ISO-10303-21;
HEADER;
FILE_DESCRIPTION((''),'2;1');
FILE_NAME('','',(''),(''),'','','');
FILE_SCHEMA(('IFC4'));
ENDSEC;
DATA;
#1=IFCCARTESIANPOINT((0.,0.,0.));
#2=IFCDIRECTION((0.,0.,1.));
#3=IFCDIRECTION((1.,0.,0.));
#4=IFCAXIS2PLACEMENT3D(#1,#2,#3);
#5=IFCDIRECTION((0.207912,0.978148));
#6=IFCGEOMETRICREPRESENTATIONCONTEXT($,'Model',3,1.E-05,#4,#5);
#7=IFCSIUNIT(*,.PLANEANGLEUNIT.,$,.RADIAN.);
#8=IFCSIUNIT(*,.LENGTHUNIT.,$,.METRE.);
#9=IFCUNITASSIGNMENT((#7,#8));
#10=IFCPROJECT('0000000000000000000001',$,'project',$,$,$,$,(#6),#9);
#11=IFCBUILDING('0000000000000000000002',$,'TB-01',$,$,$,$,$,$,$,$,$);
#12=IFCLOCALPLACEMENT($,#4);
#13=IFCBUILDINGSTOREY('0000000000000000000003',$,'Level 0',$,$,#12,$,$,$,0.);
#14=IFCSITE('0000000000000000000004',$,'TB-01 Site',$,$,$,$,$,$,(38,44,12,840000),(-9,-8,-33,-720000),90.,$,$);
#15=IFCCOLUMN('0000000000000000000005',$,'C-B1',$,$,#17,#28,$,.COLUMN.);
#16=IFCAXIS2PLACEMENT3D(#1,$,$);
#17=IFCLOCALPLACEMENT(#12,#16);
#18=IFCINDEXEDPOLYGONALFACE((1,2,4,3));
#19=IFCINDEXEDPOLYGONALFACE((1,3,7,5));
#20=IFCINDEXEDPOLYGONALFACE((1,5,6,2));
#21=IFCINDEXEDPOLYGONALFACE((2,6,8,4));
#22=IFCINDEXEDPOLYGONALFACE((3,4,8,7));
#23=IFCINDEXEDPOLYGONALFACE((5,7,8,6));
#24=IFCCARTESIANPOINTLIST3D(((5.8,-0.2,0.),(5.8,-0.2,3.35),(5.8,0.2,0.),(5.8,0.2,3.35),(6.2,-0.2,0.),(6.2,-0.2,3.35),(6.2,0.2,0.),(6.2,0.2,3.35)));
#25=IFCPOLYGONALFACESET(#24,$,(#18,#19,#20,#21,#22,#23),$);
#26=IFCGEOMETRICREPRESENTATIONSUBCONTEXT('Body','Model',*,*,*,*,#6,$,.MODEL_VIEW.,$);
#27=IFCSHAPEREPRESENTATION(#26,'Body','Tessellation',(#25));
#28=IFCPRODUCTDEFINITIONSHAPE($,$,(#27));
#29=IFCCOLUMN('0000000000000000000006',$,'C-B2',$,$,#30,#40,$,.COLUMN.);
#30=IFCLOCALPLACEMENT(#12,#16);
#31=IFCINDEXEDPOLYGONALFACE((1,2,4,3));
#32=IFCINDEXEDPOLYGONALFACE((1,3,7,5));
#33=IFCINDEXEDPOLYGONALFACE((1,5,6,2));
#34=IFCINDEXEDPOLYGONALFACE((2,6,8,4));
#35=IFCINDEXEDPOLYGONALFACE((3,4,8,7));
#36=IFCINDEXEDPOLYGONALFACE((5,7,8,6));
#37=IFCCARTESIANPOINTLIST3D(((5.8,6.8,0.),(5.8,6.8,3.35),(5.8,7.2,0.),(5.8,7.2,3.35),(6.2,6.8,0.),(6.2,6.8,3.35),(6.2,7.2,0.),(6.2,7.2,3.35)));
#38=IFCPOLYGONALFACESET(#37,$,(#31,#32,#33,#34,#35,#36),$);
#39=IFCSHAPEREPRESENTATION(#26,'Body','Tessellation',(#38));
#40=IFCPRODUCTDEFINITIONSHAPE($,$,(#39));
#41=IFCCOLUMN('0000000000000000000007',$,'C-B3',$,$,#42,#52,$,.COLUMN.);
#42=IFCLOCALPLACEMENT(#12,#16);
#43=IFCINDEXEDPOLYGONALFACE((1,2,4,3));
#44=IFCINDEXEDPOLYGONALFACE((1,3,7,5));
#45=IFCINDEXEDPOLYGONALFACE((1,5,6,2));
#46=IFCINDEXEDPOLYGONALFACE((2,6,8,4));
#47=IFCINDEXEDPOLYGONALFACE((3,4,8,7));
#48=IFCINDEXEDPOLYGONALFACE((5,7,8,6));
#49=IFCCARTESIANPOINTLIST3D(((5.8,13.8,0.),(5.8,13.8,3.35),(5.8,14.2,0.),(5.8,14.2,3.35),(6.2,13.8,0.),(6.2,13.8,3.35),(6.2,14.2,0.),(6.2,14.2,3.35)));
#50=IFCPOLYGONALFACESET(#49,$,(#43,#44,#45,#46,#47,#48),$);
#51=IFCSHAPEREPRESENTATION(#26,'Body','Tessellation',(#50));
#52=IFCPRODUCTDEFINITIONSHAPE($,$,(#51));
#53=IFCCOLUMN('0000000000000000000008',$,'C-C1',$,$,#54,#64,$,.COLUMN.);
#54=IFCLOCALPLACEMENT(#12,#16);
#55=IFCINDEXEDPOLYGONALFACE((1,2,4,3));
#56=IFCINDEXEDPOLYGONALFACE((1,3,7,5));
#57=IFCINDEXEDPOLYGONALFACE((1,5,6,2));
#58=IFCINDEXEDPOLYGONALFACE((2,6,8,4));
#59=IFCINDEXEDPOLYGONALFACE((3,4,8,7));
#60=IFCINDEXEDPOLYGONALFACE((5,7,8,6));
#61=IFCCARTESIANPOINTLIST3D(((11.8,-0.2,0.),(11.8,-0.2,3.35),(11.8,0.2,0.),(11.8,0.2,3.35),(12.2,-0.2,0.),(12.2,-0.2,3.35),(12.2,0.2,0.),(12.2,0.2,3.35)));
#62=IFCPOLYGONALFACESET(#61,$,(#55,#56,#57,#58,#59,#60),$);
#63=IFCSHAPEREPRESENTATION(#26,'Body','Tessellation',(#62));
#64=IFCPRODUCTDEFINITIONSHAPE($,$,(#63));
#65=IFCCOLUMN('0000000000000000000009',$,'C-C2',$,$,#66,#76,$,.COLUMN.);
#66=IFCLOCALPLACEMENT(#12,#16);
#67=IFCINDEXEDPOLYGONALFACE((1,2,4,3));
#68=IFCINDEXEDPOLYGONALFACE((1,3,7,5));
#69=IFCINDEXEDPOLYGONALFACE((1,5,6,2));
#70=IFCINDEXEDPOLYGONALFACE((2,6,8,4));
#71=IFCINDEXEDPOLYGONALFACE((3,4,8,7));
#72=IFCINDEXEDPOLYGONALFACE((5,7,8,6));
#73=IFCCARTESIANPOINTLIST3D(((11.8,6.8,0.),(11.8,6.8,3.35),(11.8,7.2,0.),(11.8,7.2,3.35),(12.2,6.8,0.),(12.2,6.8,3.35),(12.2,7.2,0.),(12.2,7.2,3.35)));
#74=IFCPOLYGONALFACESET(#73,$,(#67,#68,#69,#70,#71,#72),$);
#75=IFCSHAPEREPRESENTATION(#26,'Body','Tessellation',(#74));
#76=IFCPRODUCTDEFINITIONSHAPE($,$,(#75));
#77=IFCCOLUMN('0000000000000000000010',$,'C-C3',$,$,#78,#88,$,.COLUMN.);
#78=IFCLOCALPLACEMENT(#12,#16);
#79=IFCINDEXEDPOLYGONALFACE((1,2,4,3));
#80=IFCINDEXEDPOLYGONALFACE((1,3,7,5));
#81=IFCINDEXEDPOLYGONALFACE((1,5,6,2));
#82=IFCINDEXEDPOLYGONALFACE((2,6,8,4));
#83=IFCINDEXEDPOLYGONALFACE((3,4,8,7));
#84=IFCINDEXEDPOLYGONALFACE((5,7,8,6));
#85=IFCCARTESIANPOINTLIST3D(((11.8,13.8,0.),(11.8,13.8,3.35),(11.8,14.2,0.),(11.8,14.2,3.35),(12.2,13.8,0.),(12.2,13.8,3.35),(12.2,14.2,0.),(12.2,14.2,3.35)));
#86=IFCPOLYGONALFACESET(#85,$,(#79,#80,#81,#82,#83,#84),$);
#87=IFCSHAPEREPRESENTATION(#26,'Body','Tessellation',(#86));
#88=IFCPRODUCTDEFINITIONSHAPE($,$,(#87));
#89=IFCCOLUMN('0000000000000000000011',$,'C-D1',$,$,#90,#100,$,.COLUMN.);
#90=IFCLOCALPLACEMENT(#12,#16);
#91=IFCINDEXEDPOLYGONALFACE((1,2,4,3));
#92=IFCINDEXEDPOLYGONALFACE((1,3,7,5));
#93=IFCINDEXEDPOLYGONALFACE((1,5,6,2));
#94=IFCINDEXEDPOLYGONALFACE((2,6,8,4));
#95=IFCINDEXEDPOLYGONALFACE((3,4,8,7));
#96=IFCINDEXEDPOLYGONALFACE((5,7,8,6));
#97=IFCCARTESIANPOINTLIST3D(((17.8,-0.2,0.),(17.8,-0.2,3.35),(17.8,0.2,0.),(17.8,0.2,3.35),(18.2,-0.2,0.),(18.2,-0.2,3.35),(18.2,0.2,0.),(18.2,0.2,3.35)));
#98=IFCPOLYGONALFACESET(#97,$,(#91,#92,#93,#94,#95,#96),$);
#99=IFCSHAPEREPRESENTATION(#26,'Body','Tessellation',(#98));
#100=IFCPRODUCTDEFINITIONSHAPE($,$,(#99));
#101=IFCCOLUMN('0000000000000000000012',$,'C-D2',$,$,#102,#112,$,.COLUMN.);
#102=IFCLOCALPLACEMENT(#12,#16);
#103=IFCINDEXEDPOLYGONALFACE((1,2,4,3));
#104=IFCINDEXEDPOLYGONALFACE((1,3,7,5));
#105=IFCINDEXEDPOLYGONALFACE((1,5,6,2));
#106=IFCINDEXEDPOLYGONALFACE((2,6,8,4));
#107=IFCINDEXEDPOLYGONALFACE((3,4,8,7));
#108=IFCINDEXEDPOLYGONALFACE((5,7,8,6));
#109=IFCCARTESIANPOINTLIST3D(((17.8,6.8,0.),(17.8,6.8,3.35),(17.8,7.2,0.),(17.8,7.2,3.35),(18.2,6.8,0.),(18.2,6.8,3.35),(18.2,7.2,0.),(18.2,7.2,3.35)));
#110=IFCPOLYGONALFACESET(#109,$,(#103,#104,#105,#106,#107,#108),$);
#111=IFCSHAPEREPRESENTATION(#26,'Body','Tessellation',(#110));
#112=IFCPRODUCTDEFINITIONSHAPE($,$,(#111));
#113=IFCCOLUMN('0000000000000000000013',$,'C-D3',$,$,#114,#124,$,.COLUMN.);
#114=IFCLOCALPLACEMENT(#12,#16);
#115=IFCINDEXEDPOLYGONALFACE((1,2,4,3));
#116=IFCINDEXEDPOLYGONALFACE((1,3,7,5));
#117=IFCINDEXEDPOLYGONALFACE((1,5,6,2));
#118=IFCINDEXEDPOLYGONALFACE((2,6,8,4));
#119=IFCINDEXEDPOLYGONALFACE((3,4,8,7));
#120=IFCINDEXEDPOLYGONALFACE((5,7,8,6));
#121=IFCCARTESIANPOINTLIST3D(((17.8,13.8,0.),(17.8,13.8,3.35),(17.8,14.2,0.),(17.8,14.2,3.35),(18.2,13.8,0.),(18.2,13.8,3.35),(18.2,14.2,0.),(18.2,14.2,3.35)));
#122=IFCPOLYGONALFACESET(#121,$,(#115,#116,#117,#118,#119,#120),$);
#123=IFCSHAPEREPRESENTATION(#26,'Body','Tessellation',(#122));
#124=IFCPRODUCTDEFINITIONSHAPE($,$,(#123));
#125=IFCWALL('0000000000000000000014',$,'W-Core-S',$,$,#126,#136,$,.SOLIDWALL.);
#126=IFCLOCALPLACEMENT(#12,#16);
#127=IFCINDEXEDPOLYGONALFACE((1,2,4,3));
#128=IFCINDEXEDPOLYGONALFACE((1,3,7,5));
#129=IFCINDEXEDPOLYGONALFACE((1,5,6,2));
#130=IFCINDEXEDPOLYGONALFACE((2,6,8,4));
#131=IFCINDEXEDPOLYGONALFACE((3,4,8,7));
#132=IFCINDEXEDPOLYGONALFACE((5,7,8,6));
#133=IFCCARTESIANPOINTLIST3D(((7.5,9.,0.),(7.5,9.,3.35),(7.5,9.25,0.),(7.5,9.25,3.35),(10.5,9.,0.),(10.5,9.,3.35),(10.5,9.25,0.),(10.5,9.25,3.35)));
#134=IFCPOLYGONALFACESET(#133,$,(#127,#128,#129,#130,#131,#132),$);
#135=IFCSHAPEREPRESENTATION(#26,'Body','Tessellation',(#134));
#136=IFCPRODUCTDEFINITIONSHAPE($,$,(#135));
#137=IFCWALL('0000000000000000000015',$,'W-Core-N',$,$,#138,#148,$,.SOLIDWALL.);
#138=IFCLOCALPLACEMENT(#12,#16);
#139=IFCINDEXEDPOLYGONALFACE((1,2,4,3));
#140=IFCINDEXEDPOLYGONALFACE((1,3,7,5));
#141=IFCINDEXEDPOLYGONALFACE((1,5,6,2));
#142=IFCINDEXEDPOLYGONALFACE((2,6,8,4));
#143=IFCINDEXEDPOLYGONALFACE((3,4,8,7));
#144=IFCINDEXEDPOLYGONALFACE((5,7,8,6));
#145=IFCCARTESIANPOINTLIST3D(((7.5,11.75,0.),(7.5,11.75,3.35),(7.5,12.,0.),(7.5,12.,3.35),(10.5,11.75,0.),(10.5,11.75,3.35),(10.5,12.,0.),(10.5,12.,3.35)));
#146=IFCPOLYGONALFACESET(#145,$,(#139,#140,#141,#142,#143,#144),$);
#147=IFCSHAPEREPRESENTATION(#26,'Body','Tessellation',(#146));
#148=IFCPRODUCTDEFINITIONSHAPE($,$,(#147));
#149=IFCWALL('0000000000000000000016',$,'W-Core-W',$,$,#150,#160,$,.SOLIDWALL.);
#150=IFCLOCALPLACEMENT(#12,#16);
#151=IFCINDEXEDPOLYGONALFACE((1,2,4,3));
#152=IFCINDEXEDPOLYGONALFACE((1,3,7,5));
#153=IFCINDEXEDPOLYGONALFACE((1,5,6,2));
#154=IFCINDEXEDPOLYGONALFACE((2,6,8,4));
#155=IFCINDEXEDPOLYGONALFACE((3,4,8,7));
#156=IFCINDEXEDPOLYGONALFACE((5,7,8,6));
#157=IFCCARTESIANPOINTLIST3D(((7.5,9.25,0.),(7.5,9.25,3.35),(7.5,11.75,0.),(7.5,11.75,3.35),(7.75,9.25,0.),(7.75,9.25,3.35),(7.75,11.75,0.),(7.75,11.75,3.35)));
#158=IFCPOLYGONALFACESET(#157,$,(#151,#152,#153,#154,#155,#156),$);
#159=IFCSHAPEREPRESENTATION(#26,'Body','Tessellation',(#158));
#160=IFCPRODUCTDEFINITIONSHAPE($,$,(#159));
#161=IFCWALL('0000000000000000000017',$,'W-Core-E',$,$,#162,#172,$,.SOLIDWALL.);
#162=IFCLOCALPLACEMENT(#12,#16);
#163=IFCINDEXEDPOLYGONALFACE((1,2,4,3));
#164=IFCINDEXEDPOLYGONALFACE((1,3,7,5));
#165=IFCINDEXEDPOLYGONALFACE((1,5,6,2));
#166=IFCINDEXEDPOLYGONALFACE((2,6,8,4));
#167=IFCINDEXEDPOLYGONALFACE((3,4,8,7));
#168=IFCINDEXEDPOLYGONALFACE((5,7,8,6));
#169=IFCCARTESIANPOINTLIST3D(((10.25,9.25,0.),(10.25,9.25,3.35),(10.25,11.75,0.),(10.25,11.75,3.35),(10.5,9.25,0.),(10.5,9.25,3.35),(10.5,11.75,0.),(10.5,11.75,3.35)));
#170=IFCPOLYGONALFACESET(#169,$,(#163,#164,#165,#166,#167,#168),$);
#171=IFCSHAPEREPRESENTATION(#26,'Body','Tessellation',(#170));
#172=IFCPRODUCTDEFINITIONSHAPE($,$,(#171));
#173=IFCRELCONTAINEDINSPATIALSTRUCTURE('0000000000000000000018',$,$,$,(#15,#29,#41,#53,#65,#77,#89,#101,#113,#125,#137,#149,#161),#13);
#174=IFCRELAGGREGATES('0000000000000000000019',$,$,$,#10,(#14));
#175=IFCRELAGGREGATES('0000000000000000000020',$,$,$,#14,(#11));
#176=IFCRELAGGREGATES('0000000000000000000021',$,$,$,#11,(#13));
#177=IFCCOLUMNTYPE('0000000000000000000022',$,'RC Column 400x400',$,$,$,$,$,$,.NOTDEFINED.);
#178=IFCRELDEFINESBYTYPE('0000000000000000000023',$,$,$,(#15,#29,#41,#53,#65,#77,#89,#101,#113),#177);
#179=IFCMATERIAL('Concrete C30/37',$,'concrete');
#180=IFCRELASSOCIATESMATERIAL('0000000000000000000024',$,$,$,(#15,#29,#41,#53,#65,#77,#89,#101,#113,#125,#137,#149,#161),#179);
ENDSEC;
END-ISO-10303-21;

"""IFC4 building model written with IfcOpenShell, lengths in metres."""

from ifc_helpers import new_model, si_unit, direction, frame, origin_with_axes, place, context, subcontext, project, spatial, rectangle, extrude, material, type_object, element, save


model = new_model("IFC4")

# Units and contexts
model_context = context("Model", 3, precision=1e-05, world=origin_with_axes(), true_north=direction((0.207912, 0.978148)))
body_context = subcontext(model_context, "Body", "Model", "MODEL_VIEW")
ifc_project = project(units=[si_unit("PLANEANGLEUNIT", "RADIAN"), si_unit("LENGTHUNIT", "METRE")], contexts=[model_context])

# Site, building, storey
site = spatial("IfcSite", under=ifc_project, Name="TB-01 Site", RefLatitude=(38, 44, 12, 840000), RefLongitude=(-9, -8, -33, -720000), RefElevation=90.0)
building = spatial("IfcBuilding", under=site, Name="TB-01")
storey_placement = place(None, origin_with_axes())
storey = spatial("IfcBuildingStorey", under=building, at=storey_placement, Name="Level 0", Elevation=0.0)

# Columns
ifc_material_1 = material(Name="Concrete C30/37", Category="concrete")
column_type = type_object("IfcColumnType", Name="RC Column 400x400", PredefinedType="NOTDEFINED")
column_1_placement = place(storey_placement, frame((6.0, 0.0, 0.0), z_axis=(0.0, 0.0, 1.0), x_axis=(1.0, 0.0, 0.0)))
element("IfcColumn", 1, at=column_1_placement, inside=storey, type_object=column_type, material=ifc_material_1, Name="C-B1", PredefinedType="COLUMN", context=body_context, shape_type="SweptSolid", body=[
    extrude(rectangle(XDim=0.4, YDim=0.4), origin_with_axes(), (0.0, 0.0, 1.0), 3.35),
])
column_2_placement = place(storey_placement, frame((6.0, 7.0, 0.0), z_axis=(0.0, 0.0, 1.0), x_axis=(1.0, 0.0, 0.0)))
element("IfcColumn", 2, at=column_2_placement, inside=storey, type_object=column_type, material=ifc_material_1, Name="C-B2", PredefinedType="COLUMN", context=body_context, shape_type="SweptSolid", body=[
    extrude(rectangle(XDim=0.4, YDim=0.4), origin_with_axes(), (0.0, 0.0, 1.0), 3.35),
])
column_3_placement = place(storey_placement, frame((6.0, 14.0, 0.0), z_axis=(0.0, 0.0, 1.0), x_axis=(1.0, 0.0, 0.0)))
element("IfcColumn", 3, at=column_3_placement, inside=storey, type_object=column_type, material=ifc_material_1, Name="C-B3", PredefinedType="COLUMN", context=body_context, shape_type="SweptSolid", body=[
    extrude(rectangle(XDim=0.4, YDim=0.4), origin_with_axes(), (0.0, 0.0, 1.0), 3.35),
])
column_4_placement = place(storey_placement, frame((12.0, 0.0, 0.0), z_axis=(0.0, 0.0, 1.0), x_axis=(1.0, 0.0, 0.0)))
element("IfcColumn", 4, at=column_4_placement, inside=storey, type_object=column_type, material=ifc_material_1, Name="C-C1", PredefinedType="COLUMN", context=body_context, shape_type="SweptSolid", body=[
    extrude(rectangle(XDim=0.4, YDim=0.4), origin_with_axes(), (0.0, 0.0, 1.0), 3.35),
])
column_5_placement = place(storey_placement, frame((12.0, 7.0, 0.0), z_axis=(0.0, 0.0, 1.0), x_axis=(1.0, 0.0, 0.0)))
element("IfcColumn", 5, at=column_5_placement, inside=storey, type_object=column_type, material=ifc_material_1, Name="C-C2", PredefinedType="COLUMN", context=body_context, shape_type="SweptSolid", body=[
    extrude(rectangle(XDim=0.4, YDim=0.4), origin_with_axes(), (0.0, 0.0, 1.0), 3.35),
])
column_6_placement = place(storey_placement, frame((12.0, 14.0, 0.0), z_axis=(0.0, 0.0, 1.0), x_axis=(1.0, 0.0, 0.0)))
element("IfcColumn", 6, at=column_6_placement, inside=storey, type_object=column_type, material=ifc_material_1, Name="C-C3", PredefinedType="COLUMN", context=body_context, shape_type="SweptSolid", body=[
    extrude(rectangle(XDim=0.4, YDim=0.4), origin_with_axes(), (0.0, 0.0, 1.0), 3.35),
])
column_7_placement = place(storey_placement, frame((18.0, 0.0, 0.0), z_axis=(0.0, 0.0, 1.0), x_axis=(1.0, 0.0, 0.0)))
element("IfcColumn", 7, at=column_7_placement, inside=storey, type_object=column_type, material=ifc_material_1, Name="C-D1", PredefinedType="COLUMN", context=body_context, shape_type="SweptSolid", body=[
    extrude(rectangle(XDim=0.4, YDim=0.4), origin_with_axes(), (0.0, 0.0, 1.0), 3.35),
])
column_8_placement = place(storey_placement, frame((18.0, 7.0, 0.0), z_axis=(0.0, 0.0, 1.0), x_axis=(1.0, 0.0, 0.0)))
element("IfcColumn", 8, at=column_8_placement, inside=storey, type_object=column_type, material=ifc_material_1, Name="C-D2", PredefinedType="COLUMN", context=body_context, shape_type="SweptSolid", body=[
    extrude(rectangle(XDim=0.4, YDim=0.4), origin_with_axes(), (0.0, 0.0, 1.0), 3.35),
])
column_9_placement = place(storey_placement, frame((18.0, 14.0, 0.0), z_axis=(0.0, 0.0, 1.0), x_axis=(1.0, 0.0, 0.0)))
element("IfcColumn", 9, at=column_9_placement, inside=storey, type_object=column_type, material=ifc_material_1, Name="C-D3", PredefinedType="COLUMN", context=body_context, shape_type="SweptSolid", body=[
    extrude(rectangle(XDim=0.4, YDim=0.4), origin_with_axes(), (0.0, 0.0, 1.0), 3.35),
])

# Walls
for number, where, z_axis, x_axis, name in (
    (10, (9.0, 9.125, 0.0), (0.0, 0.0, 1.0), (1.0, 0.0, 0.0), "W-Core-S"),
    (11, (9.0, 11.875, 0.0), (0.0, 0.0, 1.0), (1.0, 0.0, 0.0), "W-Core-N"),
):
    element("IfcWall", number, at=place(storey_placement, frame(where, z_axis=z_axis, x_axis=x_axis)), inside=storey, material=ifc_material_1, Name=name, PredefinedType="SOLIDWALL", context=body_context, shape_type="SweptSolid", body=[
        extrude(rectangle(XDim=3.0, YDim=0.25), origin_with_axes(), (0.0, 0.0, 1.0), 3.35),
    ])
for number, where, z_axis, x_axis, name in (
    (12, (7.625, 10.5, 0.0), (0.0, 0.0, 1.0), (1.0, 0.0, 0.0), "W-Core-W"),
    (13, (10.375, 10.5, 0.0), (0.0, 0.0, 1.0), (1.0, 0.0, 0.0), "W-Core-E"),
):
    element("IfcWall", number, at=place(storey_placement, frame(where, z_axis=z_axis, x_axis=x_axis)), inside=storey, material=ifc_material_1, Name=name, PredefinedType="SOLIDWALL", context=body_context, shape_type="SweptSolid", body=[
        extrude(rectangle(XDim=0.25, YDim=2.5), origin_with_axes(), (0.0, 0.0, 1.0), 3.35),
    ])

save(model, "model.ifc")
